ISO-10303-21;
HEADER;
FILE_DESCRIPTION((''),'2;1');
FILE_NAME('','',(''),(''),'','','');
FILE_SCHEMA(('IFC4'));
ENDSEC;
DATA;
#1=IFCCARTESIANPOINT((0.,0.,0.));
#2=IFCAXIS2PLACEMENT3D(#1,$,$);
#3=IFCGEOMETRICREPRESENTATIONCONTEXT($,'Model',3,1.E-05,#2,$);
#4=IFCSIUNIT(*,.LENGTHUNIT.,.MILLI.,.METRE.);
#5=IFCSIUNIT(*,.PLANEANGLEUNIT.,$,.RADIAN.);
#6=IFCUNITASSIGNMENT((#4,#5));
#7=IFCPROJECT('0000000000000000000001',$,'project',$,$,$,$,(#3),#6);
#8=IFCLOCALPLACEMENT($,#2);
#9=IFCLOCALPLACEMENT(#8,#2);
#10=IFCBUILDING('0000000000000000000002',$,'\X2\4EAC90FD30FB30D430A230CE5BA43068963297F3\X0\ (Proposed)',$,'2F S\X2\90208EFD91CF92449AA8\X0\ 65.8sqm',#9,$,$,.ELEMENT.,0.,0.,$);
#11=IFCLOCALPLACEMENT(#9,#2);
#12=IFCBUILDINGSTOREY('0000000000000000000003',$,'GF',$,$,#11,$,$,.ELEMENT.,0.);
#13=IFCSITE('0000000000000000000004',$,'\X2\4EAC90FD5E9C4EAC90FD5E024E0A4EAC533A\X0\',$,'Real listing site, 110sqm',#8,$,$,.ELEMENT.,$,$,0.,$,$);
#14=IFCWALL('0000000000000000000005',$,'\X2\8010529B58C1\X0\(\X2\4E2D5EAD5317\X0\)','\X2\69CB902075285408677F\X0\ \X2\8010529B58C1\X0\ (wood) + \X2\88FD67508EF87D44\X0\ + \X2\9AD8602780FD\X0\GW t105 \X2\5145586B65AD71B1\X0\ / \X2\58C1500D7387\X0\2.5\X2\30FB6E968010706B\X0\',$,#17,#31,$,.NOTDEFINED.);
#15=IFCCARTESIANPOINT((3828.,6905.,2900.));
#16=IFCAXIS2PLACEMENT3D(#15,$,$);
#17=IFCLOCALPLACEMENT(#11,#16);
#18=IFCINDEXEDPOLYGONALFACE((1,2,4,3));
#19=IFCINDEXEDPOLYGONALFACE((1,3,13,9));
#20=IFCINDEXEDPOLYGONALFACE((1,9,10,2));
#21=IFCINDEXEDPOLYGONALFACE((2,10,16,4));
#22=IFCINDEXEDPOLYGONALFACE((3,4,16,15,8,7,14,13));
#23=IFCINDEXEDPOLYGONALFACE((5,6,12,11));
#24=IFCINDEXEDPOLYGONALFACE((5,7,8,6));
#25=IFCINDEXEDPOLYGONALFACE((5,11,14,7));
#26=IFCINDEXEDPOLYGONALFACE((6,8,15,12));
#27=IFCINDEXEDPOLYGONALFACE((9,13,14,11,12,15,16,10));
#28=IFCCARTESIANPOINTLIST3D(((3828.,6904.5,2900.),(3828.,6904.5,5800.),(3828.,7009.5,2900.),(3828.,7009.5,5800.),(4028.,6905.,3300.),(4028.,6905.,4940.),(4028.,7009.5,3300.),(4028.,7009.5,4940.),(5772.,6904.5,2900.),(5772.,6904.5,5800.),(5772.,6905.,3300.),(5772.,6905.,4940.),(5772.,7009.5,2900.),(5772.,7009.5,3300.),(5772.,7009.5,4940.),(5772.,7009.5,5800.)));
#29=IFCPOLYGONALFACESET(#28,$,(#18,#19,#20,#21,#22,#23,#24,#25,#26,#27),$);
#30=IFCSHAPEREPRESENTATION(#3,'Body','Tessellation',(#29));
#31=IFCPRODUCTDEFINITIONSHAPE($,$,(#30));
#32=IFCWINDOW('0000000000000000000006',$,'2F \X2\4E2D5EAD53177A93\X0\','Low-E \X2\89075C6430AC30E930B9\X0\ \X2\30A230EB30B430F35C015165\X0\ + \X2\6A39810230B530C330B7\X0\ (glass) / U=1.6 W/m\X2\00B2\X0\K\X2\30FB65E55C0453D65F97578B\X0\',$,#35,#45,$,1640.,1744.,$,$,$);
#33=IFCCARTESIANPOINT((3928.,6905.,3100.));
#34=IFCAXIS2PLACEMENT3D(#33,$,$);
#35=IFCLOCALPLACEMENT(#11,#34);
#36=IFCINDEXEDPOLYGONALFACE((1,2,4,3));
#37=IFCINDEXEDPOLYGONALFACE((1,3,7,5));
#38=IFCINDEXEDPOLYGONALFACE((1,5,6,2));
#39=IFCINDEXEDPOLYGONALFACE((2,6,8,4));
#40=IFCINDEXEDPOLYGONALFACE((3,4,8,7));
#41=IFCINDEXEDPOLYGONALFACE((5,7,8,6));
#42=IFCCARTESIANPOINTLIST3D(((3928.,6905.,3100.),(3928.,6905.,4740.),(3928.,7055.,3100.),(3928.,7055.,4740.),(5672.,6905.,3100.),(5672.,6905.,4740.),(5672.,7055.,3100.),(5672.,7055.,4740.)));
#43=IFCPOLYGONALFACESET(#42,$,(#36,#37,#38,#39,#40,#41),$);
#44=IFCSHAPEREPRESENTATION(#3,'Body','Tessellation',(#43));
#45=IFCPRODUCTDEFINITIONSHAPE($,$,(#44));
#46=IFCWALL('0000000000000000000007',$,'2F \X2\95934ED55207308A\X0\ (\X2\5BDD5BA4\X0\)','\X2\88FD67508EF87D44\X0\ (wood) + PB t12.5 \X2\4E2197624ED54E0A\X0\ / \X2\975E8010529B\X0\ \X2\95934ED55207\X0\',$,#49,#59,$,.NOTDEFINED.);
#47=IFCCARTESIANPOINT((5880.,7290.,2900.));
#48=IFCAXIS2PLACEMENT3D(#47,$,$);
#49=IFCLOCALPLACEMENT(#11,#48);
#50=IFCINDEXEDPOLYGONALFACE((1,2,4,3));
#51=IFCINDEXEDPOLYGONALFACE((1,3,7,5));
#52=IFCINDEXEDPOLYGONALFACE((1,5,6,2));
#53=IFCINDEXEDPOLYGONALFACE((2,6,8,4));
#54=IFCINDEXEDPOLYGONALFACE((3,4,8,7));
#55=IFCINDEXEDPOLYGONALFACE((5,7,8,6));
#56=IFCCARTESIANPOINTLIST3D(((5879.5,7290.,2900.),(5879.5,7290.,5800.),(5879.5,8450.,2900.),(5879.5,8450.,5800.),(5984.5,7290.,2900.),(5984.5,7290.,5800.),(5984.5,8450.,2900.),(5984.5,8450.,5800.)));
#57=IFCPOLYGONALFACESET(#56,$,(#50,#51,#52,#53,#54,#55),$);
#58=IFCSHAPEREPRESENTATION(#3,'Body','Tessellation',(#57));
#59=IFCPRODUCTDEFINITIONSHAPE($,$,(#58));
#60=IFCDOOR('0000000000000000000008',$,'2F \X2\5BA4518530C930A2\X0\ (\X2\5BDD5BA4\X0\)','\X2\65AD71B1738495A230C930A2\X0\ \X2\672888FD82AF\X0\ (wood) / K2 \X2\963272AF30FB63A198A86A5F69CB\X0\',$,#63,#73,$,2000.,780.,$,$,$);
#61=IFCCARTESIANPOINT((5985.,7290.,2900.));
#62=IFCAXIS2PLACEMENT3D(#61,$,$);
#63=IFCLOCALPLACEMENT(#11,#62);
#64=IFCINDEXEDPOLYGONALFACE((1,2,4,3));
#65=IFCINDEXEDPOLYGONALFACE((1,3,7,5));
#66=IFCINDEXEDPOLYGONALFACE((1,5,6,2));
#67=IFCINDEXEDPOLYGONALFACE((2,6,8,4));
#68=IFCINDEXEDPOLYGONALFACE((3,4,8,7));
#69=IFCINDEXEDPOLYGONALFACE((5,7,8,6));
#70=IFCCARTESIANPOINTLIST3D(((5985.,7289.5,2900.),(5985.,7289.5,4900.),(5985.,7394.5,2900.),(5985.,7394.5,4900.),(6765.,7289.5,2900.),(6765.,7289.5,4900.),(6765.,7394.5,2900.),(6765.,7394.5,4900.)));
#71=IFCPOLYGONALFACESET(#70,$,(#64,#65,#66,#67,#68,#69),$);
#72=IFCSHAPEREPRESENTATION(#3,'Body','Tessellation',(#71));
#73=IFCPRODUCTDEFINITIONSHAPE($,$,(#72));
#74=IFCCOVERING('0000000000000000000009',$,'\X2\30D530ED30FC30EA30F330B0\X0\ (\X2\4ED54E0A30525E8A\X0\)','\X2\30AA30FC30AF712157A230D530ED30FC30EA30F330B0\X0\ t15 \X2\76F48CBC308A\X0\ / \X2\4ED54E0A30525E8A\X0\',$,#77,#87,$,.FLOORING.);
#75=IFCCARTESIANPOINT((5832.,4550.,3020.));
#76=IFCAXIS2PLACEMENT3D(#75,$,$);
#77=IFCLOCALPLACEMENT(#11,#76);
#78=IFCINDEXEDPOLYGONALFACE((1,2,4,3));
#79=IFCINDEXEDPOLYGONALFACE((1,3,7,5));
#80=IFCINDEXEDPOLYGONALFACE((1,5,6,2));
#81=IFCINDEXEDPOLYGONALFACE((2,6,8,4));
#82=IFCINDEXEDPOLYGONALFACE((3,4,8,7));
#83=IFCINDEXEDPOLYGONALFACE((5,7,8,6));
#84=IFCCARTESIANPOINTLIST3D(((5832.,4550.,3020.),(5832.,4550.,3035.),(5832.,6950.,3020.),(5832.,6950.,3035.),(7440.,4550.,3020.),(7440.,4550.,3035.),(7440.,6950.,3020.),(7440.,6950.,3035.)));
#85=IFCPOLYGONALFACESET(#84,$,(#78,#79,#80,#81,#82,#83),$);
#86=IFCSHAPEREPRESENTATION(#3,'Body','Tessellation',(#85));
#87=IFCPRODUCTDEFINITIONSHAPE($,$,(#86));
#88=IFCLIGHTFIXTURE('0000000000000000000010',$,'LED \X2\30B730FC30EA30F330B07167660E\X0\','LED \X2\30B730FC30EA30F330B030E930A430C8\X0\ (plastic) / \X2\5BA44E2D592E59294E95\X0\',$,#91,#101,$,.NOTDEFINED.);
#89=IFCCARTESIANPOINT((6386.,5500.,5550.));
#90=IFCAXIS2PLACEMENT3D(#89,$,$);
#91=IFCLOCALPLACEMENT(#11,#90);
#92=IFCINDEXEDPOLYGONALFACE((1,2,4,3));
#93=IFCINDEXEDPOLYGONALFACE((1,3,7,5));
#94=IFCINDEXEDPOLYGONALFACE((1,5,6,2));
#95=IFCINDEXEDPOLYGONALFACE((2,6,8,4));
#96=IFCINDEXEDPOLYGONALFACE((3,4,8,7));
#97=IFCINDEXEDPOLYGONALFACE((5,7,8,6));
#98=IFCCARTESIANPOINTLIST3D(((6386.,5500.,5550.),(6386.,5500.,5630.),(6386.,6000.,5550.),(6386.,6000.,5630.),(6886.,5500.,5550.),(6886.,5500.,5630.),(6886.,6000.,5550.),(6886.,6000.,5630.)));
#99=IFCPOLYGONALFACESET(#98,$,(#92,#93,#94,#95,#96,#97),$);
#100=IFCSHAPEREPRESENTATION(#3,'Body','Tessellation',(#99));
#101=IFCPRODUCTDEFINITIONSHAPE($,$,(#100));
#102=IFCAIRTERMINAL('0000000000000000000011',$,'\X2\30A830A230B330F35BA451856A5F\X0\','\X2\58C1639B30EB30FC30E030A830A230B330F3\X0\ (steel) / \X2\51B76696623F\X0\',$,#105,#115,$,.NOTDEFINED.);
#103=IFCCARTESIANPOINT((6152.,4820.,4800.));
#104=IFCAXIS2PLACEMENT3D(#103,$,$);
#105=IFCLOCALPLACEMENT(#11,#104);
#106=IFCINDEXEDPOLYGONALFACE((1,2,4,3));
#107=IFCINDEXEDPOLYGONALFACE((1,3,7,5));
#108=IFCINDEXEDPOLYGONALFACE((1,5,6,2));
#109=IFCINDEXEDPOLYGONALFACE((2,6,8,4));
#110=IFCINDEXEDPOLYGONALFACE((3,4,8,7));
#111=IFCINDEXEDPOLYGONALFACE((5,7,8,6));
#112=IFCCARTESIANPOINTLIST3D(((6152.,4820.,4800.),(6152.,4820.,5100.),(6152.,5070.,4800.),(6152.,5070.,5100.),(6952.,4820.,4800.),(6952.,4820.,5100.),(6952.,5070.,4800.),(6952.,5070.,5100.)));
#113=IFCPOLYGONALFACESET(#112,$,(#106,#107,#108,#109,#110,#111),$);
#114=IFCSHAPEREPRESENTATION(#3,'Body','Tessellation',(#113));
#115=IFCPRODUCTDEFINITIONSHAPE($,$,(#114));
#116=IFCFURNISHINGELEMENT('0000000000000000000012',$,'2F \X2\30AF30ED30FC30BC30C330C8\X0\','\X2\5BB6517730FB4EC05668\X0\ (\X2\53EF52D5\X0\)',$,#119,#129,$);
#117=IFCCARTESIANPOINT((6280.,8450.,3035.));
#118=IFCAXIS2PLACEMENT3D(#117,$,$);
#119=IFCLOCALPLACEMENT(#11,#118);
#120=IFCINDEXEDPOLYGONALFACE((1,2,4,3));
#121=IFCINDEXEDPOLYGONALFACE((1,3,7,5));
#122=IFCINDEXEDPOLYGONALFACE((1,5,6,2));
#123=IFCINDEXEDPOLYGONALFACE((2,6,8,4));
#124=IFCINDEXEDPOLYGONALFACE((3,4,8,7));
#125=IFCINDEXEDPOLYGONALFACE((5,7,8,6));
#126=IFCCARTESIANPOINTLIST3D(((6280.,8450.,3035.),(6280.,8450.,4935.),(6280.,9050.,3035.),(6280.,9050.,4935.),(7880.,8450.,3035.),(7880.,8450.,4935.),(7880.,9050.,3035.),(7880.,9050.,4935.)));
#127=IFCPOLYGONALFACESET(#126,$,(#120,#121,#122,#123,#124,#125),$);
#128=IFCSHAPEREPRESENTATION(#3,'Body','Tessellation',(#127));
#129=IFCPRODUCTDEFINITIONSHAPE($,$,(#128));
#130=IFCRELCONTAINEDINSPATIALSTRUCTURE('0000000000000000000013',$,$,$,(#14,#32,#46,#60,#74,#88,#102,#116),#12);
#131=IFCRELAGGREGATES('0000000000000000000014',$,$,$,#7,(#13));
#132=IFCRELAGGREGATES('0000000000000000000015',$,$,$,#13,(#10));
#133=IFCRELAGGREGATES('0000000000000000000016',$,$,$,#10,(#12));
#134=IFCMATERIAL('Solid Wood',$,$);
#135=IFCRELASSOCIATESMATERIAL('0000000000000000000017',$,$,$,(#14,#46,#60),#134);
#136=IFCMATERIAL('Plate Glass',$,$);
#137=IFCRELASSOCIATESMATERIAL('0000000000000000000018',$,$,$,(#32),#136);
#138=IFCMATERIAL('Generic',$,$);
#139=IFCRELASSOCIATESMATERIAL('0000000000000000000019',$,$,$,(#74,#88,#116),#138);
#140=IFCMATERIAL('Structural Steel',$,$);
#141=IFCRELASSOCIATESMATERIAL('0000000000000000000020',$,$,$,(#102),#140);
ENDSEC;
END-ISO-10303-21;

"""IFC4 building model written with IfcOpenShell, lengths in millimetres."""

from ifc_helpers import new_model, si_unit, frame, frame_2d, origin, place, context, project, spatial, rectangle, extrude, material, element, fill, save


model = new_model("IFC4")

# Units and contexts
model_context = context("Model", 3, precision=1e-05, world=origin())
ifc_project = project(units=[si_unit("LENGTHUNIT", "METRE", prefix="MILLI"), si_unit("PLANEANGLEUNIT", "RADIAN")], contexts=[model_context])

# Site, building, storey
site_placement = place(None, origin())
site = spatial("IfcSite", under=ifc_project, at=site_placement, Name="京都府京都市上京区", ObjectType="Real listing site, 110sqm", CompositionType="ELEMENT", RefElevation=0.0)
building_placement = place(site_placement, origin())
building = spatial("IfcBuilding", under=site, at=building_placement, Name="京都・ピアノ室と防音 (Proposed)", ObjectType="2F S造軽量鉄骨 65.8sqm", CompositionType="ELEMENT", ElevationOfRefHeight=0.0, ElevationOfTerrain=0.0)
storey_placement = place(building_placement, origin())
storey = spatial("IfcBuildingStorey", under=building, at=storey_placement, Name="GF", CompositionType="ELEMENT", Elevation=0.0)

# Shared definitions
ifc_material_1 = material(Name="Solid Wood")

# Wall, opening, window
wall_1_placement = place(storey_placement, frame((3828.0, 6905.0, 2900.0)))
wall_1 = element("IfcWall", 1, at=wall_1_placement, inside=storey, material=ifc_material_1, Name="耐力壁(中庭北)", Description="構造用合板 耐力壁 (wood) + 製材軸組 + 高性能GW t105 充填断熱 / 壁倍率2.5・準耐火", PredefinedType="NOTDEFINED", context=model_context, shape_type="SweptSolid", body=[
    extrude(rectangle(XDim=1944.0, YDim=105.0, at=frame_2d((972.0, 52.0))), frame((3828.0, 6905.0, 2900.0)), (0.0, 0.0, 1.0), 2900.0),
])
opening_placement = place(storey_placement, frame((3928.0, 6905.0, 3100.0)))
opening = element("IfcOpeningElement", 2, at=opening_placement, cuts=wall_1, PredefinedType="NOTDEFINED", context=model_context, shape_type="SweptSolid", body=[
    extrude(rectangle(XDim=1744.0, YDim=150.0, at=frame_2d((872.0, 75.0))), frame((3928.0, 6905.0, 3100.0)), (0.0, 0.0, 1.0), 1640.0),
])
ifc_material_2 = material(Name="Plate Glass")
window_placement = place(storey_placement, frame((3928.0, 6905.0, 3100.0)))
window = element("IfcWindow", 3, at=window_placement, inside=storey, material=ifc_material_2, Name="2F 中庭北窓", Description="Low-E 複層ガラス アルゴン封入 + 樹脂サッシ (glass) / U=1.6 W/m²K・日射取得型", OverallHeight=1640.0, OverallWidth=1744.0, context=model_context, shape_type="SweptSolid", body=[
    extrude(rectangle(XDim=1744.0, YDim=150.0, at=frame_2d((872.0, 75.0))), frame((3928.0, 6905.0, 3100.0)), (0.0, 0.0, 1.0), 1640.0),
])
fill(opening, window)

# Wall
wall_2_placement = place(storey_placement, frame((5880.0, 7290.0, 2900.0)))
element("IfcWall", 4, at=wall_2_placement, inside=storey, material=ifc_material_1, Name="2F 間仕切り (寝室)", Description="製材軸組 (wood) + PB t12.5 両面仕上 / 非耐力 間仕切", PredefinedType="NOTDEFINED", context=model_context, shape_type="SweptSolid", body=[
    extrude(rectangle(XDim=105.0, YDim=1160.0, at=frame_2d((52.0, 580.0))), frame((5880.0, 7290.0, 2900.0)), (0.0, 0.0, 1.0), 2900.0),
])

# Door
door_placement = place(storey_placement, frame((5985.0, 7290.0, 2900.0)))
element("IfcDoor", 5, at=door_placement, inside=storey, material=ifc_material_1, Name="2F 室内ドア (寝室)", Description="断熱玄関ドア 木製芯 (wood) / K2 防犯・採風機構", OverallHeight=2000.0, OverallWidth=780.0, context=model_context, shape_type="SweptSolid", body=[
    extrude(rectangle(XDim=780.0, YDim=105.0, at=frame_2d((390.0, 52.0))), frame((5985.0, 7290.0, 2900.0)), (0.0, 0.0, 1.0), 2000.0),
])

# Covering
ifc_material_3 = material(Name="Generic")
covering_placement = place(storey_placement, frame((5832.0, 4550.0, 3020.0)))
element("IfcCovering", 6, at=covering_placement, inside=storey, material=ifc_material_3, Name="フローリング (仕上げ床)", Description="オーク無垢フローリング t15 直貼り / 仕上げ床", PredefinedType="FLOORING", context=model_context, shape_type="SweptSolid", body=[
    extrude(rectangle(XDim=1608.0, YDim=2400.0, at=frame_2d((804.0, 1200.0))), frame((5832.0, 4550.0, 3020.0)), (0.0, 0.0, 1.0), 15.0),
])

# Light fixture
light_fixture_placement = place(storey_placement, frame((6386.0, 5500.0, 5550.0)))
element("IfcLightFixture", 7, at=light_fixture_placement, inside=storey, material=ifc_material_3, Name="LED シーリング照明", Description="LED シーリングライト (plastic) / 室中央天井", PredefinedType="NOTDEFINED", context=model_context, shape_type="SweptSolid", body=[
    extrude(rectangle(XDim=500.0, YDim=500.0, at=frame_2d((250.0, 250.0))), frame((6386.0, 5500.0, 5550.0)), (0.0, 0.0, 1.0), 80.0),
])

# Air terminal
ifc_material_4 = material(Name="Structural Steel")
air_terminal_placement = place(storey_placement, frame((6152.0, 4820.0, 4800.0)))
element("IfcAirTerminal", 8, at=air_terminal_placement, inside=storey, material=ifc_material_4, Name="エアコン室内機", Description="壁掛ルームエアコン (steel) / 冷暖房", PredefinedType="NOTDEFINED", context=model_context, shape_type="SweptSolid", body=[
    extrude(rectangle(XDim=800.0, YDim=250.0, at=frame_2d((400.0, 125.0))), frame((6152.0, 4820.0, 4800.0)), (0.0, 0.0, 1.0), 300.0),
])

# Furnishing element
furnishing_placement = place(storey_placement, frame((6280.0, 8450.0, 3035.0)))
element("IfcFurnishingElement", 9, at=furnishing_placement, inside=storey, material=ifc_material_3, Name="2F クローゼット", Description="家具・什器 (可動)", context=model_context, shape_type="SweptSolid", body=[
    extrude(rectangle(XDim=1600.0, YDim=600.0, at=frame_2d((800.0, 300.0))), frame((6280.0, 8450.0, 3035.0)), (0.0, 0.0, 1.0), 1900.0),
])

save(model, "model.ifc")
